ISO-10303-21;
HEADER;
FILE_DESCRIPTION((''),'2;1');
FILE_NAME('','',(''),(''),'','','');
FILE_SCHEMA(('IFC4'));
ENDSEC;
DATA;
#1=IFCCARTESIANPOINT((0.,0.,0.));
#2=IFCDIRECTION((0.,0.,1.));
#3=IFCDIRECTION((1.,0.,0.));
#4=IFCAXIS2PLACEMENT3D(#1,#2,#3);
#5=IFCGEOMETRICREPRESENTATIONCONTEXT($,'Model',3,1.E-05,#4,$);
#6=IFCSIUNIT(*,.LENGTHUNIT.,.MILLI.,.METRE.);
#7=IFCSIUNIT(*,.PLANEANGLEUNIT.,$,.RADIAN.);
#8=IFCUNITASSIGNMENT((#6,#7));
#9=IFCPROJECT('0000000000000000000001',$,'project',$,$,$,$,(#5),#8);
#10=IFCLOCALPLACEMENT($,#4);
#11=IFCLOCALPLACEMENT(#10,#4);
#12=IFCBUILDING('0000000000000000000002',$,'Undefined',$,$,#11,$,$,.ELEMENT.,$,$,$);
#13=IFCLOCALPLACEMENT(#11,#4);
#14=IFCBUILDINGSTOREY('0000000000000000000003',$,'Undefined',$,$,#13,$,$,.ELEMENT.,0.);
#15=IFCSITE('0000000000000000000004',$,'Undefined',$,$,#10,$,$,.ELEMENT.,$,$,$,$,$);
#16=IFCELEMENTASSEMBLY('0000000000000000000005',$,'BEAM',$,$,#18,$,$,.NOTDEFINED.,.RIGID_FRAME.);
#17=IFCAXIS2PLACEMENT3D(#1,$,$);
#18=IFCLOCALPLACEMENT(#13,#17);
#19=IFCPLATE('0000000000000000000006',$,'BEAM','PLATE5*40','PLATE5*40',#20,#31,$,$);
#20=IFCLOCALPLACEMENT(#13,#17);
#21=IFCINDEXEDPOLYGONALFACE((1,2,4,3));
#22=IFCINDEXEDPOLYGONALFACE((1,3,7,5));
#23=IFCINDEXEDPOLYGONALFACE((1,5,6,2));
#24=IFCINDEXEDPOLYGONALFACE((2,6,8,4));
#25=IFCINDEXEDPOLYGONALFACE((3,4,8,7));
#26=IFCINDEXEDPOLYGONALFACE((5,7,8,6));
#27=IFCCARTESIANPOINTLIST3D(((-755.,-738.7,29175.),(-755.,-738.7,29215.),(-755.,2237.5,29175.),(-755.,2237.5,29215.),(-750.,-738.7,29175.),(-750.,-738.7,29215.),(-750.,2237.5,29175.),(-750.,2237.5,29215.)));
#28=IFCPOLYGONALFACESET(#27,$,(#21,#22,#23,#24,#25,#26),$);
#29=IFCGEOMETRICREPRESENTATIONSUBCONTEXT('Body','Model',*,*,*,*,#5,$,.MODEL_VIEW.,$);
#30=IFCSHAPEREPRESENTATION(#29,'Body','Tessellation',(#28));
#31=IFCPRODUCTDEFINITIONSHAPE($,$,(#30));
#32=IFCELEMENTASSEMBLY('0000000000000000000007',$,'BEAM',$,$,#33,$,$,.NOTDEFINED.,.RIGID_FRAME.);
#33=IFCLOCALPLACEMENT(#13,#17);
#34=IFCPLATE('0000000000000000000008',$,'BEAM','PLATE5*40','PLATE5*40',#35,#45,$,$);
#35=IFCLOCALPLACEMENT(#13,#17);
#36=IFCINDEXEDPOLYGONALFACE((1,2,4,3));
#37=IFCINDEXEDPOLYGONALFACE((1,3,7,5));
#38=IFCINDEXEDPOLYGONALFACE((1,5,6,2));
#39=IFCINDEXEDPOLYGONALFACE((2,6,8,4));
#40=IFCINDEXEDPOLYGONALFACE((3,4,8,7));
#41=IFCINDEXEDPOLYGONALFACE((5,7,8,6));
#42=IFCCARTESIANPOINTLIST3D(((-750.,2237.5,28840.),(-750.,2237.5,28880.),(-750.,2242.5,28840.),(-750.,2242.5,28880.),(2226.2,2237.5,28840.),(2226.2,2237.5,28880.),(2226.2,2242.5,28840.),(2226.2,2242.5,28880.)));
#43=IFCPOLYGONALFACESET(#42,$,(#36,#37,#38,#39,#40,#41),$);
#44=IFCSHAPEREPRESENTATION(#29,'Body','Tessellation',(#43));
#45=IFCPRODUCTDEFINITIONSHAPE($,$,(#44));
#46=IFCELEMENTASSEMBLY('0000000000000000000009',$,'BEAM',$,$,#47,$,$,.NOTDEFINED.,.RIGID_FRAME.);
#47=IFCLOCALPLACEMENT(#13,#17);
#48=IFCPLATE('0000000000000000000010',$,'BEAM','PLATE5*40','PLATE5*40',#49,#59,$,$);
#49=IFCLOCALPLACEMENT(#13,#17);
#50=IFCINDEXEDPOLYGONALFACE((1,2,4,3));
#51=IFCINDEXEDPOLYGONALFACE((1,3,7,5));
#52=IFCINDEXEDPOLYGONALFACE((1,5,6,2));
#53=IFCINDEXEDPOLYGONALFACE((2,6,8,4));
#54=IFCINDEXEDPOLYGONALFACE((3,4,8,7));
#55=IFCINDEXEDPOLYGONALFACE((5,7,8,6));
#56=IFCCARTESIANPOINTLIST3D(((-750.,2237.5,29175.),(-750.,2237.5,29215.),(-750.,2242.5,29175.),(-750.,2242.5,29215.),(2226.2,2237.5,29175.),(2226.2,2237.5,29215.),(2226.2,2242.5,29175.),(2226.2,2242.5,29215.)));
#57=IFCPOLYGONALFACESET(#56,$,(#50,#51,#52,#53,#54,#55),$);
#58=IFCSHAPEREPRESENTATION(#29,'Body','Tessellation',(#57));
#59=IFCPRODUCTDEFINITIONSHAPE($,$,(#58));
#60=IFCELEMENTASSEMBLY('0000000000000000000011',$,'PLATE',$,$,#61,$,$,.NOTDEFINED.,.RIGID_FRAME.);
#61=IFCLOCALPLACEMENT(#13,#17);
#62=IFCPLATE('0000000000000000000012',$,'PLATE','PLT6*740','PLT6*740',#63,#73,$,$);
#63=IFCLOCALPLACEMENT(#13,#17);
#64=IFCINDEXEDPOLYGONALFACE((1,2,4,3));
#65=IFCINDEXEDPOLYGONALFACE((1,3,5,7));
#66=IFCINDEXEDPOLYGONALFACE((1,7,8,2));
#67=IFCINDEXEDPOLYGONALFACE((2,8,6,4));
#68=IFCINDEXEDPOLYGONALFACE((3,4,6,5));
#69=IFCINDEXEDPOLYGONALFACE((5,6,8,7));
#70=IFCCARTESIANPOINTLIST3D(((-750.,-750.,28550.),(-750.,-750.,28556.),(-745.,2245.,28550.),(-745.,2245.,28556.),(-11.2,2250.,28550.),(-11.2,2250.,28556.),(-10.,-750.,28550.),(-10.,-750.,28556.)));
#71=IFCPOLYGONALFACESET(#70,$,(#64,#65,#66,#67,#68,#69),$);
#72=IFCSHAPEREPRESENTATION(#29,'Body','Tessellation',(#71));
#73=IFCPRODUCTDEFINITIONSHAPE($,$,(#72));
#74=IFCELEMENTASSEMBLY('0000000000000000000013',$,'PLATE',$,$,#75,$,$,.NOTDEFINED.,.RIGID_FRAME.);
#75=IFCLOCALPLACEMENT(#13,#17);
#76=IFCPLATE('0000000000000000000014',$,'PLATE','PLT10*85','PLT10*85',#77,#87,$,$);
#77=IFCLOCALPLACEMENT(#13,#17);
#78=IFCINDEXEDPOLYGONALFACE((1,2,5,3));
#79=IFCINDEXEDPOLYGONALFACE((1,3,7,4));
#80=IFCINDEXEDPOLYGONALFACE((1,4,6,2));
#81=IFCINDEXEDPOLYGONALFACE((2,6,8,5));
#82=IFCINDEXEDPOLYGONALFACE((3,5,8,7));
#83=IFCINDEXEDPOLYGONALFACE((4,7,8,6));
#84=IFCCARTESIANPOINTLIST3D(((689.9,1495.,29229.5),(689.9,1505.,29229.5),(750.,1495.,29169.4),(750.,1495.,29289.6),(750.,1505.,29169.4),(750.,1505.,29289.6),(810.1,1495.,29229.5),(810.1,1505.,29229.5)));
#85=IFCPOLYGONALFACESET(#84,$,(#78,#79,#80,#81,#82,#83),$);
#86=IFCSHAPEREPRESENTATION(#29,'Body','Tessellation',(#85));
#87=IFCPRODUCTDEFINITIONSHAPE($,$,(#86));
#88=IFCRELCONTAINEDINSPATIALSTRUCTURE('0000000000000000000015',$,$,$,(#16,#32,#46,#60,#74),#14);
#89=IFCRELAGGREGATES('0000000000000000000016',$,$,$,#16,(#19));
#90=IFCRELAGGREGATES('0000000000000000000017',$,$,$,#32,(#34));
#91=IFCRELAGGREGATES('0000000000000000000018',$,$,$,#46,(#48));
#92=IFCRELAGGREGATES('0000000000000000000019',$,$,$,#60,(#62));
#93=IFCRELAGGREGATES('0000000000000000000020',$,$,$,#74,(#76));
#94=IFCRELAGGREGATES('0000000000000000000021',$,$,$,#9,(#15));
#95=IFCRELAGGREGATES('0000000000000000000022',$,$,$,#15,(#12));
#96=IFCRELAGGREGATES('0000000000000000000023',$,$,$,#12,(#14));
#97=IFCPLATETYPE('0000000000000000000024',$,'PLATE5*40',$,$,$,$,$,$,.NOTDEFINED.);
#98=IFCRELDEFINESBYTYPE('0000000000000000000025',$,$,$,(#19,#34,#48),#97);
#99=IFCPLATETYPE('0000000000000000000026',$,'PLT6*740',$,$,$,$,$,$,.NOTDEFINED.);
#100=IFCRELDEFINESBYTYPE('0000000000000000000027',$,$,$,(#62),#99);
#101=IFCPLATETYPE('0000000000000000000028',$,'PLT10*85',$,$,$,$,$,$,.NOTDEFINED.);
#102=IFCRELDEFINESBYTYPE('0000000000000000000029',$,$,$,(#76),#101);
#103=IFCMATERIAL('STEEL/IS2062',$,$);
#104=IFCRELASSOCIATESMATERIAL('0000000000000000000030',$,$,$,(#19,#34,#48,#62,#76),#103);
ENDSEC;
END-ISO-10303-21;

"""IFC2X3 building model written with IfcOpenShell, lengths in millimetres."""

from ifc_helpers import new_model, si_unit, frame, origin_with_axes, place, context, subcontext, project, spatial, polyline, outline, extrude, material, type_object, element, aggregate, save


model = new_model("IFC2X3")

# Units and contexts
model_context = context("Model", 3, precision=1e-05, world=origin_with_axes())
body_context = subcontext(model_context, "Body", "Model", "MODEL_VIEW")
ifc_project = project(units=[si_unit("LENGTHUNIT", "METRE", prefix="MILLI"), si_unit("PLANEANGLEUNIT", "RADIAN")], contexts=[model_context])

# Site, building, storey
site_placement = place(None, origin_with_axes())
site = spatial("IfcSite", under=ifc_project, at=site_placement, Name="Undefined", CompositionType="ELEMENT")
building_placement = place(site_placement, origin_with_axes())
building = spatial("IfcBuilding", under=site, at=building_placement, Name="Undefined", CompositionType="ELEMENT")
storey_placement = place(building_placement, origin_with_axes())
storey = spatial("IfcBuildingStorey", under=building, at=storey_placement, Name="Undefined", CompositionType="ELEMENT", Elevation=0.0)

# Shared definitions
ifc_material = material(Name="STEEL/IS2062")

# Element assemblies, plates
plate_type_1 = type_object("IfcPlateType", Name="PLATE5*40", PredefinedType="NOTDEFINED")
assembly_1_placement = place(storey_placement, origin_with_axes())
assembly_1 = element("IfcElementAssembly", 1, at=assembly_1_placement, inside=storey, Name="BEAM", AssemblyPlace="NOTDEFINED", PredefinedType="RIGID_FRAME")
plate_1_placement = place(assembly_1_placement, frame((-752.5, 2237.5, 29195.0), z_axis=(-1.0, 0.0, 0.0), x_axis=(0.0, -1.0, 0.0)))
plate_1 = element("IfcPlate", 2, at=plate_1_placement, type_object=plate_type_1, material=ifc_material, Name="BEAM", Description="PLATE5*40", ObjectType="PLATE5*40", context=body_context, shape_type="SweptSolid", body=[
    extrude(outline(polyline([(2976.2, -20.0), (0.0, -20.0), (0.0, 20.0), (2976.2, 20.0), (2976.2, -20.0)])), frame((0.0, 0.0, -2.5), z_axis=(0.0, 0.0, 1.0), x_axis=(1.0, 0.0, 0.0)), (0.0, 0.0, 1.0), 5.0),
])
aggregate(assembly_1, [plate_1])
assembly_2_placement = place(storey_placement, origin_with_axes())
assembly_2 = element("IfcElementAssembly", 3, at=assembly_2_placement, inside=storey, Name="BEAM", AssemblyPlace="NOTDEFINED", PredefinedType="RIGID_FRAME")
plate_2_placement = place(assembly_2_placement, frame((-750.0, 2240.0, 28860.0), z_axis=(0.0, -1.0, 0.0), x_axis=(1.0, 0.0, 0.0)))
plate_2 = element("IfcPlate", 4, at=plate_2_placement, type_object=plate_type_1, material=ifc_material, Name="BEAM", Description="PLATE5*40", ObjectType="PLATE5*40", context=body_context, shape_type="SweptSolid", body=[
    extrude(outline(polyline([(0.0, -20.0), (0.0, 20.0), (2976.2, 20.0), (2976.2, -20.0), (0.0, -20.0)])), frame((0.0, 0.0, -2.5), z_axis=(0.0, 0.0, 1.0), x_axis=(1.0, 0.0, 0.0)), (0.0, 0.0, 1.0), 5.0),
])
aggregate(assembly_2, [plate_2])
assembly_3_placement = place(storey_placement, origin_with_axes())
assembly_3 = element("IfcElementAssembly", 5, at=assembly_3_placement, inside=storey, Name="BEAM", AssemblyPlace="NOTDEFINED", PredefinedType="RIGID_FRAME")
plate_3_placement = place(assembly_3_placement, frame((-750.0, 2240.0, 29195.0), z_axis=(0.0, -1.0, 0.0), x_axis=(1.0, 0.0, 0.0)))
plate_3 = element("IfcPlate", 6, at=plate_3_placement, type_object=plate_type_1, material=ifc_material, Name="BEAM", Description="PLATE5*40", ObjectType="PLATE5*40", context=body_context, shape_type="SweptSolid", body=[
    extrude(outline(polyline([(0.0, -20.0), (0.0, 20.0), (2976.2, 20.0), (2976.2, -20.0), (0.0, -20.0)])), frame((0.0, 0.0, -2.5), z_axis=(0.0, 0.0, 1.0), x_axis=(1.0, 0.0, 0.0)), (0.0, 0.0, 1.0), 5.0),
])
aggregate(assembly_3, [plate_3])
assembly_4_placement = place(storey_placement, origin_with_axes())
assembly_4 = element("IfcElementAssembly", 7, at=assembly_4_placement, inside=storey, Name="PLATE", AssemblyPlace="NOTDEFINED", PredefinedType="RIGID_FRAME")
plate_type_2 = type_object("IfcPlateType", Name="PLT6*740", PredefinedType="NOTDEFINED")
plate_4_placement = place(assembly_4_placement, frame((-11.2, 2250.0, 28553.0), z_axis=(0.0, 0.0, 1.0), x_axis=(-0.999977, -0.006814, 0.0)))
plate_4 = element("IfcPlate", 8, at=plate_4_placement, type_object=plate_type_2, material=ifc_material, Name="PLATE", Description="PLT6*740", ObjectType="PLT6*740", context=body_context, shape_type="SweptSolid", body=[
    extrude(outline(polyline([(0.0, 0.0), (733.8, 0.0), (759.2, 2994.9), (19.3, 2999.9), (0.0, 0.0), (0.0, 0.0)])), frame((0.0, 0.0, -3.0), z_axis=(0.0, 0.0, 1.0), x_axis=(1.0, 0.0, 0.0)), (0.0, 0.0, 1.0), 6.0),
])
aggregate(assembly_4, [plate_4])
assembly_5_placement = place(storey_placement, origin_with_axes())
assembly_5 = element("IfcElementAssembly", 9, at=assembly_5_placement, inside=storey, Name="PLATE", AssemblyPlace="NOTDEFINED", PredefinedType="RIGID_FRAME")
plate_type_3 = type_object("IfcPlateType", Name="PLT10*85", PredefinedType="NOTDEFINED")
plate_5_placement = place(assembly_5_placement, frame((750.0, 1500.0, 29289.6), z_axis=(0.0, -1.0, 0.0), x_axis=(-0.707107, 0.0, -0.707107)))
plate_5 = element("IfcPlate", 10, at=plate_5_placement, type_object=plate_type_3, material=ifc_material, Name="PLATE", Description="PLT10*85", ObjectType="PLT10*85", context=body_context, shape_type="SweptSolid", body=[
    extrude(outline(polyline([(0.0, 0.0), (85.0, 0.0), (85.0, 85.0), (0.0, 85.0), (0.0, 0.0)])), frame((0.0, 0.0, -5.0), z_axis=(0.0, 0.0, 1.0), x_axis=(1.0, 0.0, 0.0)), (0.0, 0.0, 1.0), 10.0),
])
aggregate(assembly_5, [plate_5])

save(model, "model.ifc")
